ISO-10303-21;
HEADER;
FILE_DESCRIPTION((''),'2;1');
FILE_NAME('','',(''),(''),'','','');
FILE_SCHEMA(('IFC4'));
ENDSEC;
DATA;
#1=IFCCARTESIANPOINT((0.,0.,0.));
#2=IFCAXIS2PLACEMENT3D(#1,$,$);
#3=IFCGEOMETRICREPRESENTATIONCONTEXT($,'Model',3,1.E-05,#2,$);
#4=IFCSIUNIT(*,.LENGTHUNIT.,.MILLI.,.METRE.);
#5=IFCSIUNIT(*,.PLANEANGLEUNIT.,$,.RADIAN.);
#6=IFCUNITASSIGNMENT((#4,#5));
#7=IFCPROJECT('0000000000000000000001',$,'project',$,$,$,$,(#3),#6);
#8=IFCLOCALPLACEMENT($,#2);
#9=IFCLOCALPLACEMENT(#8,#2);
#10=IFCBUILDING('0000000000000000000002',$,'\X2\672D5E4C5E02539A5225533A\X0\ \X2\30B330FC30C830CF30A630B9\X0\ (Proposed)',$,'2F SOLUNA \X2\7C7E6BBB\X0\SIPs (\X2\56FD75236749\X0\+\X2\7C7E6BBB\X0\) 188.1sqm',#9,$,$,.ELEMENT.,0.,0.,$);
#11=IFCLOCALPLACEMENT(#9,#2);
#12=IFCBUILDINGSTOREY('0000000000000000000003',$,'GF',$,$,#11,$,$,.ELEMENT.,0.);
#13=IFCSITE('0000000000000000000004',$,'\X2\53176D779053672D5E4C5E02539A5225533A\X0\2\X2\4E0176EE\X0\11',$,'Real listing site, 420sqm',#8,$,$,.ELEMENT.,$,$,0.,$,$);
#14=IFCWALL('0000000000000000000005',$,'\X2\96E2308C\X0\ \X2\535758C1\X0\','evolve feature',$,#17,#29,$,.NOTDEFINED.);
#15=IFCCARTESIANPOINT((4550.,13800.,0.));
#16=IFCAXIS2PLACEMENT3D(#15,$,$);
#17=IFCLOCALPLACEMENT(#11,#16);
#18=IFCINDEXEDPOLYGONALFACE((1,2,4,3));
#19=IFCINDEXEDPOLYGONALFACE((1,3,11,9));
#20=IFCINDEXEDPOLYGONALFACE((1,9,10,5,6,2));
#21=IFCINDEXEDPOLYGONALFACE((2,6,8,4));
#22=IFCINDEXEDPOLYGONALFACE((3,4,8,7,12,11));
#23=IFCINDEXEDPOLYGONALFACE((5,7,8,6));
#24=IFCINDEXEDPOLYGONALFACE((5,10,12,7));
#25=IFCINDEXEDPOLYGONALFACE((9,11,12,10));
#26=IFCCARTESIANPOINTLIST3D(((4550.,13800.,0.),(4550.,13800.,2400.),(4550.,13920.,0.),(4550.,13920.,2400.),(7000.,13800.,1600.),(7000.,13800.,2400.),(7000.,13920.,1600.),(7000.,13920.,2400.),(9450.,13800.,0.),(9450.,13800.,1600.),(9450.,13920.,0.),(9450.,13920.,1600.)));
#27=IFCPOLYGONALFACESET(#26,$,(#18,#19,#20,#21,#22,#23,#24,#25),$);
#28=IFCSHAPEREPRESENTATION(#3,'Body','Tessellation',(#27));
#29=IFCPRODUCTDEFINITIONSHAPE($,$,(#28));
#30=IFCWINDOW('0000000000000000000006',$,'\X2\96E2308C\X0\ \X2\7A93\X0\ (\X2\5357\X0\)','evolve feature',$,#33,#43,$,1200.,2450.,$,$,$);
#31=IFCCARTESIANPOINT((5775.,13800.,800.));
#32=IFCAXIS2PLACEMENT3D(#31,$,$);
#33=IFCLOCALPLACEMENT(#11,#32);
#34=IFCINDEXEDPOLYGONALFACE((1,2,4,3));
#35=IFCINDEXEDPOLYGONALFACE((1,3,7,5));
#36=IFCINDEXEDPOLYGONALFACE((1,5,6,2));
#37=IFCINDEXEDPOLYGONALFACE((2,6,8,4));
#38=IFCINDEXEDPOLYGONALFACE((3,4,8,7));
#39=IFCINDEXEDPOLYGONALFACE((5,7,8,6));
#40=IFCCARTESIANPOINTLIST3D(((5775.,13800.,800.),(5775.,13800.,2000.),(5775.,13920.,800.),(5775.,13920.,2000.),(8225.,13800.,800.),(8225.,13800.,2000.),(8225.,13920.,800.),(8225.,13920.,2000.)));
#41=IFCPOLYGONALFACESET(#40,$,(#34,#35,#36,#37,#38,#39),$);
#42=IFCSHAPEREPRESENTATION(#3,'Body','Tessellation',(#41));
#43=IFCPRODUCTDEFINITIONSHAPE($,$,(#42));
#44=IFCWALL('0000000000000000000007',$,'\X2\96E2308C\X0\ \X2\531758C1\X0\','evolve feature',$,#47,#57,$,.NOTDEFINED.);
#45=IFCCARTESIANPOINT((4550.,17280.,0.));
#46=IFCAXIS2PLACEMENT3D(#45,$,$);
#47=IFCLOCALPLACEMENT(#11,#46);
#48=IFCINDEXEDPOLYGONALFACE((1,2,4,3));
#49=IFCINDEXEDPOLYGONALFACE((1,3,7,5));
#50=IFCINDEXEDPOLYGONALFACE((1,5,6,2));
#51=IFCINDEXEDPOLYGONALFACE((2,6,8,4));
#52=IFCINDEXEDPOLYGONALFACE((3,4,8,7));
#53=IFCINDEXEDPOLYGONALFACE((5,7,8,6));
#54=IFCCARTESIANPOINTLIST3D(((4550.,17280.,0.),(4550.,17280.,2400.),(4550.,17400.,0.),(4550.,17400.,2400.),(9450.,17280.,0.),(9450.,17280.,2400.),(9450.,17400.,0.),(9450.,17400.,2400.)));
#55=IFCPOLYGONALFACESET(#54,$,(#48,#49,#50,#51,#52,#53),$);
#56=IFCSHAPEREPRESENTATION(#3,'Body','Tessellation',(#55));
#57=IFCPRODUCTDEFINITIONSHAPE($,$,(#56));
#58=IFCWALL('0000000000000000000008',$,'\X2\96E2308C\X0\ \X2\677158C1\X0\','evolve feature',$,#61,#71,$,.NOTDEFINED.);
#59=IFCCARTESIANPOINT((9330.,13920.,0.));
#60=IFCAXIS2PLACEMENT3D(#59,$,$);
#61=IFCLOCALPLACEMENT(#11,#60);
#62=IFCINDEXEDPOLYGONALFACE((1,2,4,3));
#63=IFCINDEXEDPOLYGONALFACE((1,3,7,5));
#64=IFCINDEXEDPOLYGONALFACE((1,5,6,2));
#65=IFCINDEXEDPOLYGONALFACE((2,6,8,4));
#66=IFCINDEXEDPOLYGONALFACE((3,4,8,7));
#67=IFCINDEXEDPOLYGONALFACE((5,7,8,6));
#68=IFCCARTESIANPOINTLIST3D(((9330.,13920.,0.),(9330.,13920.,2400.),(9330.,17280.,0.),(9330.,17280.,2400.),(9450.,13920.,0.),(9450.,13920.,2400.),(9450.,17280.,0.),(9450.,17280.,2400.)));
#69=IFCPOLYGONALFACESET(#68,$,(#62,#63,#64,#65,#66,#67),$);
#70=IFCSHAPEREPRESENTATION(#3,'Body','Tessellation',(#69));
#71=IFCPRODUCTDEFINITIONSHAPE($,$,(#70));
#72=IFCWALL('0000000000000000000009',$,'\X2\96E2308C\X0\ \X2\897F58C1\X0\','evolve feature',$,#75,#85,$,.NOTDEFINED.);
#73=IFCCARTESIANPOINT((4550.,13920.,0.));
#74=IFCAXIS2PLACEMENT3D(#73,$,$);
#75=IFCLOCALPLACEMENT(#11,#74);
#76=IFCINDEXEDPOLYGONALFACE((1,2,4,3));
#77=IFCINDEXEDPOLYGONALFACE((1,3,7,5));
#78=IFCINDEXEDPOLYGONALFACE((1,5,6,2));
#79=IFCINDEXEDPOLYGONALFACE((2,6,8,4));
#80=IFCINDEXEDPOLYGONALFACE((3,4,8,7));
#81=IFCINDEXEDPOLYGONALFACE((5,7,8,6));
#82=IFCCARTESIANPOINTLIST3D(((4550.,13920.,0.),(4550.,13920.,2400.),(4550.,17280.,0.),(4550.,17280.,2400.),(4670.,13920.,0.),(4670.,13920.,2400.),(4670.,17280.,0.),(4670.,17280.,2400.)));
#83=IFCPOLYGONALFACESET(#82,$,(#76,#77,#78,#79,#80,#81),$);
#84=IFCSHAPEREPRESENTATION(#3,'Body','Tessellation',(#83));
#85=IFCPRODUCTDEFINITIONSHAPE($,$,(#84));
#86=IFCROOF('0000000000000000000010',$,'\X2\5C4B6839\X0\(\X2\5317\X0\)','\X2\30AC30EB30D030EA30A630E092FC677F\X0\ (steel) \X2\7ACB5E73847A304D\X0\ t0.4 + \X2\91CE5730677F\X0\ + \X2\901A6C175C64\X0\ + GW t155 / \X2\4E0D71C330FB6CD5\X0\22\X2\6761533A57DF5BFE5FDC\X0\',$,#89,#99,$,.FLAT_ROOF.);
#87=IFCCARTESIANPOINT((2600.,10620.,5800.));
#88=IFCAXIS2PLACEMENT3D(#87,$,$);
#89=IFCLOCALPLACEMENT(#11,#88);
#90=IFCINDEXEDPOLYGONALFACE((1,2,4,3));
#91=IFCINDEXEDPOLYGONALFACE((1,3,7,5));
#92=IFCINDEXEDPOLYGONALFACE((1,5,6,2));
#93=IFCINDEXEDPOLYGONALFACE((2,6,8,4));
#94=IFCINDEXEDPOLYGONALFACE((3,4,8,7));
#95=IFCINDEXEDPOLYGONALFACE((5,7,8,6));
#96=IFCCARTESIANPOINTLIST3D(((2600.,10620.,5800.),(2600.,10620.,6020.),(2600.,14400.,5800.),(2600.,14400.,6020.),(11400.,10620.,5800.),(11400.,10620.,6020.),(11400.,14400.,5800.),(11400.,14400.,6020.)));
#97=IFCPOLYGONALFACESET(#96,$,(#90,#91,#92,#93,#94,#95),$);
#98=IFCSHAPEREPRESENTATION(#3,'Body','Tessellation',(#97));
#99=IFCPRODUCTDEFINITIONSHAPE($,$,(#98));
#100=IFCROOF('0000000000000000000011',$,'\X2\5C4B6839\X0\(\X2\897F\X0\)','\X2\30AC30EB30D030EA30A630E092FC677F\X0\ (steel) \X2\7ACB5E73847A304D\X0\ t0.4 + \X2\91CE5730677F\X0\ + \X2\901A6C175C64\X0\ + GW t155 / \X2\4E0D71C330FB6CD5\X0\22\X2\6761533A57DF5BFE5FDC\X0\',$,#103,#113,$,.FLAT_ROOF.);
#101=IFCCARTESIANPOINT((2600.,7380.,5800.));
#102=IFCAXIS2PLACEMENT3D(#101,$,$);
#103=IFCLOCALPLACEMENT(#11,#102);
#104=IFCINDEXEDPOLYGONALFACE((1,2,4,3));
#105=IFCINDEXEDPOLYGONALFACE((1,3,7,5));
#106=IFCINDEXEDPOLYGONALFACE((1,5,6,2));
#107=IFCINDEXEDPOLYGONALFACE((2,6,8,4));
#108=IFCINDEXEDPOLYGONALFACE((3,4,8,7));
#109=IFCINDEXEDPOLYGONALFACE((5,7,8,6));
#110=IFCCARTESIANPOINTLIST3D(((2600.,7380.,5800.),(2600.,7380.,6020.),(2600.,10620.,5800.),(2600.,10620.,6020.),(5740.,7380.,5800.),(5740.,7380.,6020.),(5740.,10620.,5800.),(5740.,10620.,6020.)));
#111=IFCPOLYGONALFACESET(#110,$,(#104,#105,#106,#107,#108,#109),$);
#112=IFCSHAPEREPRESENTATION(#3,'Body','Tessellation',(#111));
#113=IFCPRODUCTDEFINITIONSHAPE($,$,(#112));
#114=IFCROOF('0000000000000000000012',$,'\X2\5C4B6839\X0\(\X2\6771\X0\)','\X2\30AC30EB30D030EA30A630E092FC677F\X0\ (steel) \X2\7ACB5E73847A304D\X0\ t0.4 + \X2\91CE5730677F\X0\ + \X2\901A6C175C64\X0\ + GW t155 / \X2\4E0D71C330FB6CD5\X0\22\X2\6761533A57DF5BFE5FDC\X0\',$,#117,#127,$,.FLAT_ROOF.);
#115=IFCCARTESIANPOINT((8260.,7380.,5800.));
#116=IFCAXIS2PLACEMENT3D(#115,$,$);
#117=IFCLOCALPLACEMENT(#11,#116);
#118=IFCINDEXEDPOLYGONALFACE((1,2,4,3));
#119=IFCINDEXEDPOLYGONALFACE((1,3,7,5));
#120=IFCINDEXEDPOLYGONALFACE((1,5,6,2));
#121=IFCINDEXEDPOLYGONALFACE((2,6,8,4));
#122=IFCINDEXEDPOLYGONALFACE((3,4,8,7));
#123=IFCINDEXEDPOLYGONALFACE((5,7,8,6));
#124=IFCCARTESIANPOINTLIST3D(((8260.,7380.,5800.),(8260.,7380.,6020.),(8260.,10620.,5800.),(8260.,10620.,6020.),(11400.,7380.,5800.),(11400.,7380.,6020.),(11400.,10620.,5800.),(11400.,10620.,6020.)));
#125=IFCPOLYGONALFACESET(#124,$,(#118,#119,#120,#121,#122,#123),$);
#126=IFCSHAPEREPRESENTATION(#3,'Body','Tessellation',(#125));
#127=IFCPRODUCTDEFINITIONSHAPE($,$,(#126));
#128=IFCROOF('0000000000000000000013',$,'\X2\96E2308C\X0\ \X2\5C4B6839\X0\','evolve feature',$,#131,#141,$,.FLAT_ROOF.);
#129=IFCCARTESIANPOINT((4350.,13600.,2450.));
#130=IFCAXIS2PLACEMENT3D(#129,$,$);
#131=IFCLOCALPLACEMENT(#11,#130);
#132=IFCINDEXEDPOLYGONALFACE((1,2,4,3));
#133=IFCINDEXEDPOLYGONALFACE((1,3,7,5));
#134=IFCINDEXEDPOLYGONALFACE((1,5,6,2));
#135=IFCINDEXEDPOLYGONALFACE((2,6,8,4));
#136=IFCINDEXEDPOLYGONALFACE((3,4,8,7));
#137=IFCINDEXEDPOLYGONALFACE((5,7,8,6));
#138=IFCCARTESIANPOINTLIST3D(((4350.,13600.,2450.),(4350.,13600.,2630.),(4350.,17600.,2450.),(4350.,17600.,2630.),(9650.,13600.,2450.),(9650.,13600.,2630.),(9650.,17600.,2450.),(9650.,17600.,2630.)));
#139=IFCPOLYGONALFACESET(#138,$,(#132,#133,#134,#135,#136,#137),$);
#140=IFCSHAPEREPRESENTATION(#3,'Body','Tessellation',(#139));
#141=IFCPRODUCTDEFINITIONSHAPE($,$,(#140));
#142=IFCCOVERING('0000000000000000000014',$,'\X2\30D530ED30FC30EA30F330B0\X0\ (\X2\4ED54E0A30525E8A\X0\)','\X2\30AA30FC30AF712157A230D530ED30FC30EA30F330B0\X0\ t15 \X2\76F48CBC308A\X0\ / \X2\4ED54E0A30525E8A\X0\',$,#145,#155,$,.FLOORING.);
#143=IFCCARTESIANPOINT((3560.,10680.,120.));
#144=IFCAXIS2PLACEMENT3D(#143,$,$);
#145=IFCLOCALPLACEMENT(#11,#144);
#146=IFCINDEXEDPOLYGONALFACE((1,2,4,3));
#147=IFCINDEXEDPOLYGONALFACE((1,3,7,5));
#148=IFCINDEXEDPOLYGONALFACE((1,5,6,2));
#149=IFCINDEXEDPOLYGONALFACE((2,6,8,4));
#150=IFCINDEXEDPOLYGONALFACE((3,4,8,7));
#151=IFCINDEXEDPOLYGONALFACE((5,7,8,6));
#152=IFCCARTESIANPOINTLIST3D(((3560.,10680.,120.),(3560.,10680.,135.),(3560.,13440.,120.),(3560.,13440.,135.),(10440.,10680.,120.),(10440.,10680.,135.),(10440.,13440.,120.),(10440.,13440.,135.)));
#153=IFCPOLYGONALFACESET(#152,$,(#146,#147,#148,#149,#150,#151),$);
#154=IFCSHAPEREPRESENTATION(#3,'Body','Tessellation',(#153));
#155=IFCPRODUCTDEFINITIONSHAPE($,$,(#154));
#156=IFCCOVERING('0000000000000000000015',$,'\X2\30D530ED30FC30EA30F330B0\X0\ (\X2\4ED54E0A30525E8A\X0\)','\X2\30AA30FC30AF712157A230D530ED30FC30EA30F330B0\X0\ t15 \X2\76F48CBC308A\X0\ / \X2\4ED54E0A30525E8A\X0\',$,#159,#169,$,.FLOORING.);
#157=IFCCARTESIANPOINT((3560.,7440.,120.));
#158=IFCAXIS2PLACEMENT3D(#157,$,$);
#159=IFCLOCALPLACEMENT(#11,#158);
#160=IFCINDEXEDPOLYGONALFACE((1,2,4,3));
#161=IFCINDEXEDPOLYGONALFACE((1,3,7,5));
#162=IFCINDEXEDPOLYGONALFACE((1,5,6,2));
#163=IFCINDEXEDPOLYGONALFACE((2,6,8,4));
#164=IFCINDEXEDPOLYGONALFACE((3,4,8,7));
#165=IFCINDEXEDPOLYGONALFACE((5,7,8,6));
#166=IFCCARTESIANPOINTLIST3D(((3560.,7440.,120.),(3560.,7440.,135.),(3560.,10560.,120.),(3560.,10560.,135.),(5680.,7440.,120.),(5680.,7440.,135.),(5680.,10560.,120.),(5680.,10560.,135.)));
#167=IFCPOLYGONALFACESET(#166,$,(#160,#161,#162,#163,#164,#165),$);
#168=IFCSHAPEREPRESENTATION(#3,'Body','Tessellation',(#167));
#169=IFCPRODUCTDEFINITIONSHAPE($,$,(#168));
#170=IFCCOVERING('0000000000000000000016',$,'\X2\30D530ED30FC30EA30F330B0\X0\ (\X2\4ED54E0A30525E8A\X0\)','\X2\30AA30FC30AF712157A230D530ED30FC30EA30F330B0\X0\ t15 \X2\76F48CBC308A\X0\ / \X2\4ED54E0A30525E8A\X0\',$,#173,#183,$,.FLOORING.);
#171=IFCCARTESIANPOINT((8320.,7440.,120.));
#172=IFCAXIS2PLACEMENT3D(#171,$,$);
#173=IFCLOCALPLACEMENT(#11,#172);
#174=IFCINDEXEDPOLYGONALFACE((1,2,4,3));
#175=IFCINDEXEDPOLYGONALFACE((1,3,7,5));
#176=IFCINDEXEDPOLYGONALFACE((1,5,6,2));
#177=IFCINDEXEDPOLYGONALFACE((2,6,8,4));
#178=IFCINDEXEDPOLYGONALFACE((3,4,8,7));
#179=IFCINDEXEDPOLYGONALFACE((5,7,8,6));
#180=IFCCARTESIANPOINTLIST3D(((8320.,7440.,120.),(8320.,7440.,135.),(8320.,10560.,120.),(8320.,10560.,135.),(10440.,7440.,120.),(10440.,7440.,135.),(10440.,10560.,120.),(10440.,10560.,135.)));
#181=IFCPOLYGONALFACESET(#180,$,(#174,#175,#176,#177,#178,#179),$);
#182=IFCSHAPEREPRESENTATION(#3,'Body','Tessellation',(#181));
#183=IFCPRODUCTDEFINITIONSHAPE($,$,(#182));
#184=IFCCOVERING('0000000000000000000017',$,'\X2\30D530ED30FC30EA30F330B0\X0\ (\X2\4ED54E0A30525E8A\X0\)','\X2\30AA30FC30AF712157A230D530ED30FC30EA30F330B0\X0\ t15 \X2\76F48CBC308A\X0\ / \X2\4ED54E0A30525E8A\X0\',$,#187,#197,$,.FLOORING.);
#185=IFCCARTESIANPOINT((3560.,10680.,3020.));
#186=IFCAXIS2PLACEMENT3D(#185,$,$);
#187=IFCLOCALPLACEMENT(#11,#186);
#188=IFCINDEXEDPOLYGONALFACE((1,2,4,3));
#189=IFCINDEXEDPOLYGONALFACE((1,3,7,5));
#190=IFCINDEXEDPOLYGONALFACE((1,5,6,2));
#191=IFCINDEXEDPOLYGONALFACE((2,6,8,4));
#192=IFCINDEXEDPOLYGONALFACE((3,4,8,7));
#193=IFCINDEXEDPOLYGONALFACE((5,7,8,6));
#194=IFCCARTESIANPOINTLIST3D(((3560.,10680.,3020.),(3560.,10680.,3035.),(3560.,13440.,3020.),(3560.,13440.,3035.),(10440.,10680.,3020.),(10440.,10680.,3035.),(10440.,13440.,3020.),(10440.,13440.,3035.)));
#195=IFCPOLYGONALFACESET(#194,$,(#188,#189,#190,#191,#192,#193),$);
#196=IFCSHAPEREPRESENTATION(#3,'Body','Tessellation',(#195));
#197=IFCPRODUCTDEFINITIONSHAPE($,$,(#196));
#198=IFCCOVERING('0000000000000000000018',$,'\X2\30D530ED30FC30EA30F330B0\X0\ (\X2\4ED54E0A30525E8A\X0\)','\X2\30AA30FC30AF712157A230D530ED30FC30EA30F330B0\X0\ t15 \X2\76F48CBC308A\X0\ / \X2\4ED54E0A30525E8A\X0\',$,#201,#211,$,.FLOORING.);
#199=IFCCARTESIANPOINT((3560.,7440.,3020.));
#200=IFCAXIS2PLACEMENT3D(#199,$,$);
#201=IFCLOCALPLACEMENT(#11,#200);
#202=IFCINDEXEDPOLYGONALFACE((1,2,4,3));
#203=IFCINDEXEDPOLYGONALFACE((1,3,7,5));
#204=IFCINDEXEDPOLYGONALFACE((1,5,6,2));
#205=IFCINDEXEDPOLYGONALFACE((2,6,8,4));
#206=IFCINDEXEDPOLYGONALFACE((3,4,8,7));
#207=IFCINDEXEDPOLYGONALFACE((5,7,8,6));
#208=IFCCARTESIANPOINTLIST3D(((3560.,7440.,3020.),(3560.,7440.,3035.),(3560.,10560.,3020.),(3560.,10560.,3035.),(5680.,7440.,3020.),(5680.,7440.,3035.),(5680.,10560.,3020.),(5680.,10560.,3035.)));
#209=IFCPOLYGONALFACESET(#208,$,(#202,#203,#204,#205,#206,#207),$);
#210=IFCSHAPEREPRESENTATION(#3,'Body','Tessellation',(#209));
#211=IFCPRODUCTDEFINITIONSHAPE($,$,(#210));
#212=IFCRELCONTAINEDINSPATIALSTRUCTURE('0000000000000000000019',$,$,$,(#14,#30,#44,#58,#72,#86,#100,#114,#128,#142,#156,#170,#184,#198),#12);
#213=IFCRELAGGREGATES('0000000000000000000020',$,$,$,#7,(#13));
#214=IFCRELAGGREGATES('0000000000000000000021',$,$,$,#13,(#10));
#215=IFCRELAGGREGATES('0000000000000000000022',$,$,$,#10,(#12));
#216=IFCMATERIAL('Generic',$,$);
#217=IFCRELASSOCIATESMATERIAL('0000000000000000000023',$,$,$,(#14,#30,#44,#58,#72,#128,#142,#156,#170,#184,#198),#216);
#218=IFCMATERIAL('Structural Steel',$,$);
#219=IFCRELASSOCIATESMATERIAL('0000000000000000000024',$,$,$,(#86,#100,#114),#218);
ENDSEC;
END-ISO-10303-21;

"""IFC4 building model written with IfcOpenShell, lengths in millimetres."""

from ifc_helpers import new_model, si_unit, frame, frame_2d, origin, place, context, project, spatial, rectangle, extrude, material, element, fill, save


model = new_model("IFC4")

# Units and contexts
model_context = context("Model", 3, precision=1e-05, world=origin())
ifc_project = project(units=[si_unit("LENGTHUNIT", "METRE", prefix="MILLI"), si_unit("PLANEANGLEUNIT", "RADIAN")], contexts=[model_context])

# Site, building, storey
site_placement = place(None, origin())
site = spatial("IfcSite", under=ifc_project, at=site_placement, Name="北海道札幌市厚別区2丁目11", ObjectType="Real listing site, 420sqm", CompositionType="ELEMENT", RefElevation=0.0)
building_placement = place(site_placement, origin())
building = spatial("IfcBuilding", under=site, at=building_placement, Name="札幌市厚別区 コートハウス (Proposed)", ObjectType="2F SOLUNA 籾殻SIPs (国産杉+籾殻) 188.1sqm", CompositionType="ELEMENT", ElevationOfRefHeight=0.0, ElevationOfTerrain=0.0)
storey_placement = place(building_placement, origin())
storey = spatial("IfcBuildingStorey", under=building, at=storey_placement, Name="GF", CompositionType="ELEMENT", Elevation=0.0)

# Shared definitions
ifc_material_1 = material(Name="Generic")

# Wall, opening, window
wall_1_placement = place(storey_placement, frame((4550.0, 13800.0, 0.0)))
wall_1 = element("IfcWall", 1, at=wall_1_placement, inside=storey, material=ifc_material_1, Name="離れ 南壁", Description="evolve feature", PredefinedType="NOTDEFINED", context=model_context, shape_type="SweptSolid", body=[
    extrude(rectangle(XDim=4900.0, YDim=120.0, at=frame_2d((2450.0, 60.0))), frame((4550.0, 13800.0, 0.0)), (0.0, 0.0, 1.0), 2400.0),
])
opening_1_placement = place(storey_placement, frame((5775.0, 13800.0, 800.0)))
opening_1 = element("IfcOpeningElement", 2, at=opening_1_placement, cuts=wall_1, PredefinedType="NOTDEFINED", context=model_context, shape_type="SweptSolid", body=[
    extrude(rectangle(XDim=2450.0, YDim=120.0, at=frame_2d((1225.0, 60.0))), frame((5775.0, 13800.0, 800.0)), (0.0, 0.0, 1.0), 1200.0),
])
window_1_placement = place(storey_placement, frame((5775.0, 13800.0, 800.0)))
window_1 = element("IfcWindow", 3, at=window_1_placement, inside=storey, material=ifc_material_1, Name="離れ 窓 (南)", Description="evolve feature", OverallHeight=1200.0, OverallWidth=2450.0, context=model_context, shape_type="SweptSolid", body=[
    extrude(rectangle(XDim=2450.0, YDim=120.0, at=frame_2d((1225.0, 60.0))), frame((5775.0, 13800.0, 800.0)), (0.0, 0.0, 1.0), 1200.0),
])
fill(opening_1, window_1)

# Walls
wall_2_placement = place(storey_placement, frame((4550.0, 17280.0, 0.0)))
element("IfcWall", 4, at=wall_2_placement, inside=storey, material=ifc_material_1, Name="離れ 北壁", Description="evolve feature", PredefinedType="NOTDEFINED", context=model_context, shape_type="SweptSolid", body=[
    extrude(rectangle(XDim=4900.0, YDim=120.0, at=frame_2d((2450.0, 60.0))), frame((4550.0, 17280.0, 0.0)), (0.0, 0.0, 1.0), 2400.0),
])
wall_3_placement = place(storey_placement, frame((9330.0, 13920.0, 0.0)))
element("IfcWall", 5, at=wall_3_placement, inside=storey, material=ifc_material_1, Name="離れ 東壁", Description="evolve feature", PredefinedType="NOTDEFINED", context=model_context, shape_type="SweptSolid", body=[
    extrude(rectangle(XDim=120.0, YDim=3360.0, at=frame_2d((60.0, 1680.0))), frame((9330.0, 13920.0, 0.0)), (0.0, 0.0, 1.0), 2400.0),
])
wall_4_placement = place(storey_placement, frame((4550.0, 13920.0, 0.0)))
element("IfcWall", 6, at=wall_4_placement, inside=storey, material=ifc_material_1, Name="離れ 西壁", Description="evolve feature", PredefinedType="NOTDEFINED", context=model_context, shape_type="SweptSolid", body=[
    extrude(rectangle(XDim=120.0, YDim=3360.0, at=frame_2d((60.0, 1680.0))), frame((4550.0, 13920.0, 0.0)), (0.0, 0.0, 1.0), 2400.0),
])

# Roofs
ifc_material_2 = material(Name="Structural Steel")
for number, where, name in (
    (7, (2600.0, 10620.0, 5800.0), "屋根(北)"),
):
    element("IfcRoof", number, at=place(storey_placement, frame(where)), inside=storey, material=ifc_material_2, Name=name, Description="ガルバリウム鋼板 (steel) 立平葺き t0.4 + 野地板 + 通気層 + GW t155 / 不燃・法22条区域対応", PredefinedType="FLAT_ROOF", context=model_context, shape_type="SweptSolid", body=[
        extrude(rectangle(XDim=8800.0, YDim=3780.0, at=frame_2d((4400.0, 1890.0))), frame((2600.0, 10620.0, 5800.0)), (0.0, 0.0, 1.0), 220.0),
    ])
roof_1_placement = place(storey_placement, frame((2600.0, 7380.0, 5800.0)))
element("IfcRoof", 8, at=roof_1_placement, inside=storey, material=ifc_material_2, Name="屋根(西)", Description="ガルバリウム鋼板 (steel) 立平葺き t0.4 + 野地板 + 通気層 + GW t155 / 不燃・法22条区域対応", PredefinedType="FLAT_ROOF", context=model_context, shape_type="SweptSolid", body=[
    extrude(rectangle(XDim=3140.0, YDim=3240.0, at=frame_2d((1570.0, 1620.0))), frame((2600.0, 7380.0, 5800.0)), (0.0, 0.0, 1.0), 220.0),
])
roof_2_placement = place(storey_placement, frame((8260.0, 7380.0, 5800.0)))
element("IfcRoof", 9, at=roof_2_placement, inside=storey, material=ifc_material_2, Name="屋根(東)", Description="ガルバリウム鋼板 (steel) 立平葺き t0.4 + 野地板 + 通気層 + GW t155 / 不燃・法22条区域対応", PredefinedType="FLAT_ROOF", context=model_context, shape_type="SweptSolid", body=[
    extrude(rectangle(XDim=3140.0, YDim=3240.0, at=frame_2d((1570.0, 1620.0))), frame((8260.0, 7380.0, 5800.0)), (0.0, 0.0, 1.0), 220.0),
])
roof_3_placement = place(storey_placement, frame((4350.0, 13600.0, 2450.0)))
element("IfcRoof", 10, at=roof_3_placement, inside=storey, material=ifc_material_1, Name="離れ 屋根", Description="evolve feature", PredefinedType="FLAT_ROOF", context=model_context, shape_type="SweptSolid", body=[
    extrude(rectangle(XDim=5300.0, YDim=4000.0, at=frame_2d((2650.0, 2000.0))), frame((4350.0, 13600.0, 2450.0)), (0.0, 0.0, 1.0), 180.0),
])

# Coverings
covering_1_placement = place(storey_placement, frame((3560.0, 10680.0, 120.0)))
element("IfcCovering", 11, at=covering_1_placement, inside=storey, material=ifc_material_1, Name="フローリング (仕上げ床)", Description="オーク無垢フローリング t15 直貼り / 仕上げ床", PredefinedType="FLOORING", context=model_context, shape_type="SweptSolid", body=[
    extrude(rectangle(XDim=6880.0, YDim=2760.0, at=frame_2d((3440.0, 1380.0))), frame((3560.0, 10680.0, 120.0)), (0.0, 0.0, 1.0), 15.0),
])
covering_2_placement = place(storey_placement, frame((3560.0, 7440.0, 120.0)))
element("IfcCovering", 12, at=covering_2_placement, inside=storey, material=ifc_material_1, Name="フローリング (仕上げ床)", Description="オーク無垢フローリング t15 直貼り / 仕上げ床", PredefinedType="FLOORING", context=model_context, shape_type="SweptSolid", body=[
    extrude(rectangle(XDim=2120.0, YDim=3120.0, at=frame_2d((1060.0, 1560.0))), frame((3560.0, 7440.0, 120.0)), (0.0, 0.0, 1.0), 15.0),
])
covering_3_placement = place(storey_placement, frame((8320.0, 7440.0, 120.0)))
element("IfcCovering", 13, at=covering_3_placement, inside=storey, material=ifc_material_1, Name="フローリング (仕上げ床)", Description="オーク無垢フローリング t15 直貼り / 仕上げ床", PredefinedType="FLOORING", context=model_context, shape_type="SweptSolid", body=[
    extrude(rectangle(XDim=2120.0, YDim=3120.0, at=frame_2d((1060.0, 1560.0))), frame((8320.0, 7440.0, 120.0)), (0.0, 0.0, 1.0), 15.0),
])
covering_4_placement = place(storey_placement, frame((3560.0, 10680.0, 3020.0)))
element("IfcCovering", 14, at=covering_4_placement, inside=storey, material=ifc_material_1, Name="フローリング (仕上げ床)", Description="オーク無垢フローリング t15 直貼り / 仕上げ床", PredefinedType="FLOORING", context=model_context, shape_type="SweptSolid", body=[
    extrude(rectangle(XDim=6880.0, YDim=2760.0, at=frame_2d((3440.0, 1380.0))), frame((3560.0, 10680.0, 3020.0)), (0.0, 0.0, 1.0), 15.0),
])
covering_5_placement = place(storey_placement, frame((3560.0, 7440.0, 3020.0)))
element("IfcCovering", 15, at=covering_5_placement, inside=storey, material=ifc_material_1, Name="フローリング (仕上げ床)", Description="オーク無垢フローリング t15 直貼り / 仕上げ床", PredefinedType="FLOORING", context=model_context, shape_type="SweptSolid", body=[
    extrude(rectangle(XDim=2120.0, YDim=3120.0, at=frame_2d((1060.0, 1560.0))), frame((3560.0, 7440.0, 3020.0)), (0.0, 0.0, 1.0), 15.0),
])

save(model, "model.ifc")
